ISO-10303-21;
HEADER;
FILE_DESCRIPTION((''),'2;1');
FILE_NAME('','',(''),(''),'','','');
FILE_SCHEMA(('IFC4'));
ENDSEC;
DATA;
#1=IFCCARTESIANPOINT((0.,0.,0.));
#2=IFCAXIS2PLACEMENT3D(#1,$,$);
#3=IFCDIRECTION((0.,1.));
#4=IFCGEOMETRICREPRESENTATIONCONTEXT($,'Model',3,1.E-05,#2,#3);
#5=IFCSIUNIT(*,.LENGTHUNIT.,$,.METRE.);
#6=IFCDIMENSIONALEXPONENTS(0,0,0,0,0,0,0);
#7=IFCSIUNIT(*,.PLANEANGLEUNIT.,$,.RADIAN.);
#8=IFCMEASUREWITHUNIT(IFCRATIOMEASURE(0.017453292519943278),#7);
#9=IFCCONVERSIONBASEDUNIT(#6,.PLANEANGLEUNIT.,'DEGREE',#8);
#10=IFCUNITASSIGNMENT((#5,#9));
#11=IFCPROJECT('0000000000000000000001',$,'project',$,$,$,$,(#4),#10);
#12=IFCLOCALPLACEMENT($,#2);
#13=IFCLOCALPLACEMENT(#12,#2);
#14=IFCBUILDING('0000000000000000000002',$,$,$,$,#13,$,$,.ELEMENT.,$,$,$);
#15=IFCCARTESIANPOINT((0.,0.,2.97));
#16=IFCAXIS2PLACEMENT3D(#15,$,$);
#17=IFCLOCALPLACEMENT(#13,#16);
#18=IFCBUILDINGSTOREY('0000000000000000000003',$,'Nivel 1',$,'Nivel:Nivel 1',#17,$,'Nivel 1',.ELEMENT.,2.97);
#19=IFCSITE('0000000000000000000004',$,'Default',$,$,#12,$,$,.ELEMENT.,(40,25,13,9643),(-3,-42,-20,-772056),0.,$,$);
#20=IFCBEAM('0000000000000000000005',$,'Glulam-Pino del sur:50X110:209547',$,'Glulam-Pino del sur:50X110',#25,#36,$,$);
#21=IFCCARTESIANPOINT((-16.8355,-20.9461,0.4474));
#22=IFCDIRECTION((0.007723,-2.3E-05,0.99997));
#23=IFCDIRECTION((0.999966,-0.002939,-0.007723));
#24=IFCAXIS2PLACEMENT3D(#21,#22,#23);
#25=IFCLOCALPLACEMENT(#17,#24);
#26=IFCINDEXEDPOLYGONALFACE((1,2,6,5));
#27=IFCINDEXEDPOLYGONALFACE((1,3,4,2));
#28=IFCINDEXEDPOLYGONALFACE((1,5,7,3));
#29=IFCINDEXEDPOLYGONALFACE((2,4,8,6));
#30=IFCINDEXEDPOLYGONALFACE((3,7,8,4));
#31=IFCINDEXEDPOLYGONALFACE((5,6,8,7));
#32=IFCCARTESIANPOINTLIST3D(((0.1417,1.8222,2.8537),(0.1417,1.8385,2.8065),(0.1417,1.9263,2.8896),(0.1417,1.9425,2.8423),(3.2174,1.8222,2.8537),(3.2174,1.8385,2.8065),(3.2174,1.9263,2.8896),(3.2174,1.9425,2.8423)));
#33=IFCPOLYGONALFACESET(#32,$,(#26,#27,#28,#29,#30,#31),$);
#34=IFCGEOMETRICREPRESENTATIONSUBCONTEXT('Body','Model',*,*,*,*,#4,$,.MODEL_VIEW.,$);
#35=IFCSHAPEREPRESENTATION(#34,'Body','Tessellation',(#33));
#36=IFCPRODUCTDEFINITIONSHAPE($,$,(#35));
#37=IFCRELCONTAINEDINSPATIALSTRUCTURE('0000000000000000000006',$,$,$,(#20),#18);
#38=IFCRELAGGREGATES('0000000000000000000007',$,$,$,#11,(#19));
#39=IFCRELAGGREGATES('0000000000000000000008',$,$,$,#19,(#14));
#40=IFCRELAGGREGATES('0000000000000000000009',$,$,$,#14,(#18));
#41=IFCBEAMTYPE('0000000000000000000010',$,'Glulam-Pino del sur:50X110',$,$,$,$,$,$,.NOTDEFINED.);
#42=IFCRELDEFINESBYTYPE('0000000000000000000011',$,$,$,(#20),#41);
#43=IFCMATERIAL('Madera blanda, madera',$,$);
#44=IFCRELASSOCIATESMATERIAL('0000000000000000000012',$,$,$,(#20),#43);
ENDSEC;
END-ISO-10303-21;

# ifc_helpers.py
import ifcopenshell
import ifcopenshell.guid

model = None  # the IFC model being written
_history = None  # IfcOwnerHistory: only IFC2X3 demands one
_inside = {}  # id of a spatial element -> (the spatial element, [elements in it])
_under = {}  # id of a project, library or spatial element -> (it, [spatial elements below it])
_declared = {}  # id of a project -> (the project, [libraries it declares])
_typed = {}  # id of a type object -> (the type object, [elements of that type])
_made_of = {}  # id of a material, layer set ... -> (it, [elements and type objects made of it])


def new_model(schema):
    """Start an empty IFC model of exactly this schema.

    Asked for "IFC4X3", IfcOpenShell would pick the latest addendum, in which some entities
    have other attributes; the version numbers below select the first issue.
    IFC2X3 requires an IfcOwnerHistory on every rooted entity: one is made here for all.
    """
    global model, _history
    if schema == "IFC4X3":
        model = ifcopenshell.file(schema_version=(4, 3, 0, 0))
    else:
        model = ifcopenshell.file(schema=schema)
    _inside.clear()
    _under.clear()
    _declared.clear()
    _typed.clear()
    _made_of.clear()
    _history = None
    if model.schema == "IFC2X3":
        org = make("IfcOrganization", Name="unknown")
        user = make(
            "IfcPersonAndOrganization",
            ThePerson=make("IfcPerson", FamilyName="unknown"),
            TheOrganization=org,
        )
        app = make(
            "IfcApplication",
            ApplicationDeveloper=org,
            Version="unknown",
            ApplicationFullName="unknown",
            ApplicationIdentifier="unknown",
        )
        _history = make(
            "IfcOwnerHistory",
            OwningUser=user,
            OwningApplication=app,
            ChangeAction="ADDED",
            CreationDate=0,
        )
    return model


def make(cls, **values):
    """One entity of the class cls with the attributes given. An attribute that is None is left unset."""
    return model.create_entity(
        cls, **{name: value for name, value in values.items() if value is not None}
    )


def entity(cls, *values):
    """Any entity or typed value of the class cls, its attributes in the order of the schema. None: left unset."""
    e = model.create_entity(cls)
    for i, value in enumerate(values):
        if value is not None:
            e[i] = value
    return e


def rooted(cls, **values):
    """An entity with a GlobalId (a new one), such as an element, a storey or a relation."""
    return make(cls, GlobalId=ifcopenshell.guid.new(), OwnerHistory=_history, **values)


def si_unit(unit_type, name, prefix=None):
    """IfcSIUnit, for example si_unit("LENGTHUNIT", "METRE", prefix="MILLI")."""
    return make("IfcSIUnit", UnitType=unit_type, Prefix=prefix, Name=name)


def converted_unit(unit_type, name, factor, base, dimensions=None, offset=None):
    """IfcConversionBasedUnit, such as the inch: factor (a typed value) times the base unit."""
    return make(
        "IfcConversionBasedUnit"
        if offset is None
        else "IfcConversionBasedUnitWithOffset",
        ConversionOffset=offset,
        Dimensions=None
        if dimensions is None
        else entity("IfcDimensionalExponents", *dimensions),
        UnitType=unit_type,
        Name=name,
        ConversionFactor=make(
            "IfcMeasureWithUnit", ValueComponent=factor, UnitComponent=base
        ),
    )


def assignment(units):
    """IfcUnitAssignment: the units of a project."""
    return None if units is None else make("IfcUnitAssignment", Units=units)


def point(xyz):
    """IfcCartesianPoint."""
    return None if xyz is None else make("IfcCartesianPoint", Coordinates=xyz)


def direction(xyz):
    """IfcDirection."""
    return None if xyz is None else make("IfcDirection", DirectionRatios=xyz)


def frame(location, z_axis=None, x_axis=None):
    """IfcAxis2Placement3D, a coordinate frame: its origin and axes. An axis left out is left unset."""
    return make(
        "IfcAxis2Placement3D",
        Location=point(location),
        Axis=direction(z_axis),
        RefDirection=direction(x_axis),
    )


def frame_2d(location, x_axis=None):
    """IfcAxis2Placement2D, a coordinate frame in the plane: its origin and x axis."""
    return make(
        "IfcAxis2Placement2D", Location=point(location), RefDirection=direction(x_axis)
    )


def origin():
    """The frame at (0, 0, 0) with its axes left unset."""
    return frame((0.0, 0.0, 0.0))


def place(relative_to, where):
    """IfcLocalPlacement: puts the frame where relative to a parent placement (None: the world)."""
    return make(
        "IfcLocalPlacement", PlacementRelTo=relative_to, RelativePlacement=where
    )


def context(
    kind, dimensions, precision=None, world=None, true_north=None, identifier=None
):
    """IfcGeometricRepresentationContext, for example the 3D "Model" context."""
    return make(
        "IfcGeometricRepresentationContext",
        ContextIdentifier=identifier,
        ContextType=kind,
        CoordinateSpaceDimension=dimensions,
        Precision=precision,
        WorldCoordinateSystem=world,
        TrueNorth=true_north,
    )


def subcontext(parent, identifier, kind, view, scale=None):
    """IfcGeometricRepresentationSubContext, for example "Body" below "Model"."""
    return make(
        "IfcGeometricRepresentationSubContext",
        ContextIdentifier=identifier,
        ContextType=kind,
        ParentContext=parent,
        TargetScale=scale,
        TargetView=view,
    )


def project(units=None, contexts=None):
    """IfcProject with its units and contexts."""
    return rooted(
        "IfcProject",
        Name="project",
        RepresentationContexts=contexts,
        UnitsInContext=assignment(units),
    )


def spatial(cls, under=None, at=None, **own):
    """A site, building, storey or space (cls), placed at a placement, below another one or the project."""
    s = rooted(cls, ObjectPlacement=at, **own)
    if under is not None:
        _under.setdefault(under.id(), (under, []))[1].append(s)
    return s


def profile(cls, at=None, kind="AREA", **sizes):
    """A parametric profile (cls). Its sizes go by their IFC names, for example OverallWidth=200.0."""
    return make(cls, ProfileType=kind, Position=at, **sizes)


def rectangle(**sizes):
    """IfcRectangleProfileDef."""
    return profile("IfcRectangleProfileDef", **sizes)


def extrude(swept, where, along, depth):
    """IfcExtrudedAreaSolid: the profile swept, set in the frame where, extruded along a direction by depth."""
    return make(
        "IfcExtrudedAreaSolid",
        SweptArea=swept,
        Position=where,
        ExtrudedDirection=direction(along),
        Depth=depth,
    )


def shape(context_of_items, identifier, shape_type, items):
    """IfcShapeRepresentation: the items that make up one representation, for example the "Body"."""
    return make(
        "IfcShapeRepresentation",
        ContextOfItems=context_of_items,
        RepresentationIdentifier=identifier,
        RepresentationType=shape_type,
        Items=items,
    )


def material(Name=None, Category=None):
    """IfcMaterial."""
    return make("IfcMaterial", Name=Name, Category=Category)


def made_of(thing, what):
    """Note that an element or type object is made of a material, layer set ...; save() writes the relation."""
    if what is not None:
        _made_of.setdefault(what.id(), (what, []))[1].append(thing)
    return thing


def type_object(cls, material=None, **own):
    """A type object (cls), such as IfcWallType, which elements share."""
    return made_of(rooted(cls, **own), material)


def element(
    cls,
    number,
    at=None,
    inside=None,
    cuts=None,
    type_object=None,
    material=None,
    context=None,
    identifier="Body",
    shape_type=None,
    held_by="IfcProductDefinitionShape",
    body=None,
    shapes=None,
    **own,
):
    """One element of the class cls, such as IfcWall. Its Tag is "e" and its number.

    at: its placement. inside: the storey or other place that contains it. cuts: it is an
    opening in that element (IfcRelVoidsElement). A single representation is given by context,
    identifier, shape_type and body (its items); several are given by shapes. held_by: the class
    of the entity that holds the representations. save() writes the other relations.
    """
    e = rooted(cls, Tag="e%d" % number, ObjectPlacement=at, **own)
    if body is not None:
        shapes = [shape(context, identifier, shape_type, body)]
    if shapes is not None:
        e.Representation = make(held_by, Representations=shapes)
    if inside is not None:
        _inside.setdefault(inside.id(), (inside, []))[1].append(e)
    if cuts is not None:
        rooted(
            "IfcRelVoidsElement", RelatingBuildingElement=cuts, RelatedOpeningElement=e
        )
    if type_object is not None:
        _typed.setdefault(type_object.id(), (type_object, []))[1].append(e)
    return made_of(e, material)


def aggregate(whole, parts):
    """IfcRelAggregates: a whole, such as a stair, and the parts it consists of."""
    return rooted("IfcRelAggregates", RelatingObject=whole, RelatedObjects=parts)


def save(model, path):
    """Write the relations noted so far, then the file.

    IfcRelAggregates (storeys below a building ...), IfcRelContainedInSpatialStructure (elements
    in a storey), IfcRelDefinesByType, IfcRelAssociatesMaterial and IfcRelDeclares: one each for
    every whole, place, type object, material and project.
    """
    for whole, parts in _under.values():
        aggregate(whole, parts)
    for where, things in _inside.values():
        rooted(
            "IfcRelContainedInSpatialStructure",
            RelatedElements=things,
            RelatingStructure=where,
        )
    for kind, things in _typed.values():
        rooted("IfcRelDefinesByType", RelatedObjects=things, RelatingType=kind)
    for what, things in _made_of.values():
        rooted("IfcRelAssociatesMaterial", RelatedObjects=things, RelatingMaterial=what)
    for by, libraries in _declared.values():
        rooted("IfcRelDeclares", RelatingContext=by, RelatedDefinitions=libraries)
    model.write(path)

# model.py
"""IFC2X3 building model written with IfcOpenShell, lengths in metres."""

from ifc_helpers import new_model, entity, si_unit, converted_unit, direction, frame, frame_2d, origin, place, context, subcontext, project, spatial, rectangle, extrude, material, type_object, element, save


model = new_model("IFC2X3")

# Units and contexts
model_context = context("Model", 3, precision=1e-05, world=origin(), true_north=direction((0.0, 1.0)))
body_context = subcontext(model_context, "Body", "Model", "MODEL_VIEW")
ifc_project = project(units=[si_unit("LENGTHUNIT", "METRE"), converted_unit("PLANEANGLEUNIT", "DEGREE", entity("IfcRatioMeasure", 0.017453292519943278), si_unit("PLANEANGLEUNIT", "RADIAN"), dimensions=[0, 0, 0, 0, 0, 0, 0])], contexts=[model_context])

# Site, building, storey
site_placement = place(None, origin())
site = spatial("IfcSite", under=ifc_project, at=site_placement, Name="Default", CompositionType="ELEMENT", RefLatitude=(40, 25, 13, 9643), RefLongitude=(-3, -42, -20, -772056), RefElevation=0.0)
building_placement = place(site_placement, origin())
building = spatial("IfcBuilding", under=site, at=building_placement, CompositionType="ELEMENT")
storey_placement = place(building_placement, frame((0.0, 0.0, 2.97)))
storey = spatial("IfcBuildingStorey", under=building, at=storey_placement, Name="Nivel 1", ObjectType="Nivel:Nivel 1", LongName="Nivel 1", CompositionType="ELEMENT", Elevation=2.97)

# Beam
ifc_material_1 = material(Name="Madera blanda, madera")
beam_type = type_object("IfcBeamType", Name="Glulam-Pino del sur:50X110", PredefinedType="NOTDEFINED")
beam_placement = place(storey_placement, frame((-16.8355, -20.9461, 0.4474), z_axis=(0.007723, -0.000023, 0.99997), x_axis=(0.999966, -0.002939, -0.007723)))
element("IfcBeam", 1, at=beam_placement, inside=storey, type_object=beam_type, material=ifc_material_1, Name="Glulam-Pino del sur:50X110:209547", ObjectType="Glulam-Pino del sur:50X110", context=body_context, shape_type="SweptSolid", body=[
    extrude(rectangle(XDim=0.05, YDim=0.11, at=frame_2d((0.0, 0.0), x_axis=(0.0, 1.0))), frame((0.1417, 1.8824, 2.848), z_axis=(1.0, 0.0, 0.0), x_axis=(0.0, -0.945519, -0.325568)), (0.0, 0.0, 1.0), 3.0757),
])

save(model, "model.ifc")
